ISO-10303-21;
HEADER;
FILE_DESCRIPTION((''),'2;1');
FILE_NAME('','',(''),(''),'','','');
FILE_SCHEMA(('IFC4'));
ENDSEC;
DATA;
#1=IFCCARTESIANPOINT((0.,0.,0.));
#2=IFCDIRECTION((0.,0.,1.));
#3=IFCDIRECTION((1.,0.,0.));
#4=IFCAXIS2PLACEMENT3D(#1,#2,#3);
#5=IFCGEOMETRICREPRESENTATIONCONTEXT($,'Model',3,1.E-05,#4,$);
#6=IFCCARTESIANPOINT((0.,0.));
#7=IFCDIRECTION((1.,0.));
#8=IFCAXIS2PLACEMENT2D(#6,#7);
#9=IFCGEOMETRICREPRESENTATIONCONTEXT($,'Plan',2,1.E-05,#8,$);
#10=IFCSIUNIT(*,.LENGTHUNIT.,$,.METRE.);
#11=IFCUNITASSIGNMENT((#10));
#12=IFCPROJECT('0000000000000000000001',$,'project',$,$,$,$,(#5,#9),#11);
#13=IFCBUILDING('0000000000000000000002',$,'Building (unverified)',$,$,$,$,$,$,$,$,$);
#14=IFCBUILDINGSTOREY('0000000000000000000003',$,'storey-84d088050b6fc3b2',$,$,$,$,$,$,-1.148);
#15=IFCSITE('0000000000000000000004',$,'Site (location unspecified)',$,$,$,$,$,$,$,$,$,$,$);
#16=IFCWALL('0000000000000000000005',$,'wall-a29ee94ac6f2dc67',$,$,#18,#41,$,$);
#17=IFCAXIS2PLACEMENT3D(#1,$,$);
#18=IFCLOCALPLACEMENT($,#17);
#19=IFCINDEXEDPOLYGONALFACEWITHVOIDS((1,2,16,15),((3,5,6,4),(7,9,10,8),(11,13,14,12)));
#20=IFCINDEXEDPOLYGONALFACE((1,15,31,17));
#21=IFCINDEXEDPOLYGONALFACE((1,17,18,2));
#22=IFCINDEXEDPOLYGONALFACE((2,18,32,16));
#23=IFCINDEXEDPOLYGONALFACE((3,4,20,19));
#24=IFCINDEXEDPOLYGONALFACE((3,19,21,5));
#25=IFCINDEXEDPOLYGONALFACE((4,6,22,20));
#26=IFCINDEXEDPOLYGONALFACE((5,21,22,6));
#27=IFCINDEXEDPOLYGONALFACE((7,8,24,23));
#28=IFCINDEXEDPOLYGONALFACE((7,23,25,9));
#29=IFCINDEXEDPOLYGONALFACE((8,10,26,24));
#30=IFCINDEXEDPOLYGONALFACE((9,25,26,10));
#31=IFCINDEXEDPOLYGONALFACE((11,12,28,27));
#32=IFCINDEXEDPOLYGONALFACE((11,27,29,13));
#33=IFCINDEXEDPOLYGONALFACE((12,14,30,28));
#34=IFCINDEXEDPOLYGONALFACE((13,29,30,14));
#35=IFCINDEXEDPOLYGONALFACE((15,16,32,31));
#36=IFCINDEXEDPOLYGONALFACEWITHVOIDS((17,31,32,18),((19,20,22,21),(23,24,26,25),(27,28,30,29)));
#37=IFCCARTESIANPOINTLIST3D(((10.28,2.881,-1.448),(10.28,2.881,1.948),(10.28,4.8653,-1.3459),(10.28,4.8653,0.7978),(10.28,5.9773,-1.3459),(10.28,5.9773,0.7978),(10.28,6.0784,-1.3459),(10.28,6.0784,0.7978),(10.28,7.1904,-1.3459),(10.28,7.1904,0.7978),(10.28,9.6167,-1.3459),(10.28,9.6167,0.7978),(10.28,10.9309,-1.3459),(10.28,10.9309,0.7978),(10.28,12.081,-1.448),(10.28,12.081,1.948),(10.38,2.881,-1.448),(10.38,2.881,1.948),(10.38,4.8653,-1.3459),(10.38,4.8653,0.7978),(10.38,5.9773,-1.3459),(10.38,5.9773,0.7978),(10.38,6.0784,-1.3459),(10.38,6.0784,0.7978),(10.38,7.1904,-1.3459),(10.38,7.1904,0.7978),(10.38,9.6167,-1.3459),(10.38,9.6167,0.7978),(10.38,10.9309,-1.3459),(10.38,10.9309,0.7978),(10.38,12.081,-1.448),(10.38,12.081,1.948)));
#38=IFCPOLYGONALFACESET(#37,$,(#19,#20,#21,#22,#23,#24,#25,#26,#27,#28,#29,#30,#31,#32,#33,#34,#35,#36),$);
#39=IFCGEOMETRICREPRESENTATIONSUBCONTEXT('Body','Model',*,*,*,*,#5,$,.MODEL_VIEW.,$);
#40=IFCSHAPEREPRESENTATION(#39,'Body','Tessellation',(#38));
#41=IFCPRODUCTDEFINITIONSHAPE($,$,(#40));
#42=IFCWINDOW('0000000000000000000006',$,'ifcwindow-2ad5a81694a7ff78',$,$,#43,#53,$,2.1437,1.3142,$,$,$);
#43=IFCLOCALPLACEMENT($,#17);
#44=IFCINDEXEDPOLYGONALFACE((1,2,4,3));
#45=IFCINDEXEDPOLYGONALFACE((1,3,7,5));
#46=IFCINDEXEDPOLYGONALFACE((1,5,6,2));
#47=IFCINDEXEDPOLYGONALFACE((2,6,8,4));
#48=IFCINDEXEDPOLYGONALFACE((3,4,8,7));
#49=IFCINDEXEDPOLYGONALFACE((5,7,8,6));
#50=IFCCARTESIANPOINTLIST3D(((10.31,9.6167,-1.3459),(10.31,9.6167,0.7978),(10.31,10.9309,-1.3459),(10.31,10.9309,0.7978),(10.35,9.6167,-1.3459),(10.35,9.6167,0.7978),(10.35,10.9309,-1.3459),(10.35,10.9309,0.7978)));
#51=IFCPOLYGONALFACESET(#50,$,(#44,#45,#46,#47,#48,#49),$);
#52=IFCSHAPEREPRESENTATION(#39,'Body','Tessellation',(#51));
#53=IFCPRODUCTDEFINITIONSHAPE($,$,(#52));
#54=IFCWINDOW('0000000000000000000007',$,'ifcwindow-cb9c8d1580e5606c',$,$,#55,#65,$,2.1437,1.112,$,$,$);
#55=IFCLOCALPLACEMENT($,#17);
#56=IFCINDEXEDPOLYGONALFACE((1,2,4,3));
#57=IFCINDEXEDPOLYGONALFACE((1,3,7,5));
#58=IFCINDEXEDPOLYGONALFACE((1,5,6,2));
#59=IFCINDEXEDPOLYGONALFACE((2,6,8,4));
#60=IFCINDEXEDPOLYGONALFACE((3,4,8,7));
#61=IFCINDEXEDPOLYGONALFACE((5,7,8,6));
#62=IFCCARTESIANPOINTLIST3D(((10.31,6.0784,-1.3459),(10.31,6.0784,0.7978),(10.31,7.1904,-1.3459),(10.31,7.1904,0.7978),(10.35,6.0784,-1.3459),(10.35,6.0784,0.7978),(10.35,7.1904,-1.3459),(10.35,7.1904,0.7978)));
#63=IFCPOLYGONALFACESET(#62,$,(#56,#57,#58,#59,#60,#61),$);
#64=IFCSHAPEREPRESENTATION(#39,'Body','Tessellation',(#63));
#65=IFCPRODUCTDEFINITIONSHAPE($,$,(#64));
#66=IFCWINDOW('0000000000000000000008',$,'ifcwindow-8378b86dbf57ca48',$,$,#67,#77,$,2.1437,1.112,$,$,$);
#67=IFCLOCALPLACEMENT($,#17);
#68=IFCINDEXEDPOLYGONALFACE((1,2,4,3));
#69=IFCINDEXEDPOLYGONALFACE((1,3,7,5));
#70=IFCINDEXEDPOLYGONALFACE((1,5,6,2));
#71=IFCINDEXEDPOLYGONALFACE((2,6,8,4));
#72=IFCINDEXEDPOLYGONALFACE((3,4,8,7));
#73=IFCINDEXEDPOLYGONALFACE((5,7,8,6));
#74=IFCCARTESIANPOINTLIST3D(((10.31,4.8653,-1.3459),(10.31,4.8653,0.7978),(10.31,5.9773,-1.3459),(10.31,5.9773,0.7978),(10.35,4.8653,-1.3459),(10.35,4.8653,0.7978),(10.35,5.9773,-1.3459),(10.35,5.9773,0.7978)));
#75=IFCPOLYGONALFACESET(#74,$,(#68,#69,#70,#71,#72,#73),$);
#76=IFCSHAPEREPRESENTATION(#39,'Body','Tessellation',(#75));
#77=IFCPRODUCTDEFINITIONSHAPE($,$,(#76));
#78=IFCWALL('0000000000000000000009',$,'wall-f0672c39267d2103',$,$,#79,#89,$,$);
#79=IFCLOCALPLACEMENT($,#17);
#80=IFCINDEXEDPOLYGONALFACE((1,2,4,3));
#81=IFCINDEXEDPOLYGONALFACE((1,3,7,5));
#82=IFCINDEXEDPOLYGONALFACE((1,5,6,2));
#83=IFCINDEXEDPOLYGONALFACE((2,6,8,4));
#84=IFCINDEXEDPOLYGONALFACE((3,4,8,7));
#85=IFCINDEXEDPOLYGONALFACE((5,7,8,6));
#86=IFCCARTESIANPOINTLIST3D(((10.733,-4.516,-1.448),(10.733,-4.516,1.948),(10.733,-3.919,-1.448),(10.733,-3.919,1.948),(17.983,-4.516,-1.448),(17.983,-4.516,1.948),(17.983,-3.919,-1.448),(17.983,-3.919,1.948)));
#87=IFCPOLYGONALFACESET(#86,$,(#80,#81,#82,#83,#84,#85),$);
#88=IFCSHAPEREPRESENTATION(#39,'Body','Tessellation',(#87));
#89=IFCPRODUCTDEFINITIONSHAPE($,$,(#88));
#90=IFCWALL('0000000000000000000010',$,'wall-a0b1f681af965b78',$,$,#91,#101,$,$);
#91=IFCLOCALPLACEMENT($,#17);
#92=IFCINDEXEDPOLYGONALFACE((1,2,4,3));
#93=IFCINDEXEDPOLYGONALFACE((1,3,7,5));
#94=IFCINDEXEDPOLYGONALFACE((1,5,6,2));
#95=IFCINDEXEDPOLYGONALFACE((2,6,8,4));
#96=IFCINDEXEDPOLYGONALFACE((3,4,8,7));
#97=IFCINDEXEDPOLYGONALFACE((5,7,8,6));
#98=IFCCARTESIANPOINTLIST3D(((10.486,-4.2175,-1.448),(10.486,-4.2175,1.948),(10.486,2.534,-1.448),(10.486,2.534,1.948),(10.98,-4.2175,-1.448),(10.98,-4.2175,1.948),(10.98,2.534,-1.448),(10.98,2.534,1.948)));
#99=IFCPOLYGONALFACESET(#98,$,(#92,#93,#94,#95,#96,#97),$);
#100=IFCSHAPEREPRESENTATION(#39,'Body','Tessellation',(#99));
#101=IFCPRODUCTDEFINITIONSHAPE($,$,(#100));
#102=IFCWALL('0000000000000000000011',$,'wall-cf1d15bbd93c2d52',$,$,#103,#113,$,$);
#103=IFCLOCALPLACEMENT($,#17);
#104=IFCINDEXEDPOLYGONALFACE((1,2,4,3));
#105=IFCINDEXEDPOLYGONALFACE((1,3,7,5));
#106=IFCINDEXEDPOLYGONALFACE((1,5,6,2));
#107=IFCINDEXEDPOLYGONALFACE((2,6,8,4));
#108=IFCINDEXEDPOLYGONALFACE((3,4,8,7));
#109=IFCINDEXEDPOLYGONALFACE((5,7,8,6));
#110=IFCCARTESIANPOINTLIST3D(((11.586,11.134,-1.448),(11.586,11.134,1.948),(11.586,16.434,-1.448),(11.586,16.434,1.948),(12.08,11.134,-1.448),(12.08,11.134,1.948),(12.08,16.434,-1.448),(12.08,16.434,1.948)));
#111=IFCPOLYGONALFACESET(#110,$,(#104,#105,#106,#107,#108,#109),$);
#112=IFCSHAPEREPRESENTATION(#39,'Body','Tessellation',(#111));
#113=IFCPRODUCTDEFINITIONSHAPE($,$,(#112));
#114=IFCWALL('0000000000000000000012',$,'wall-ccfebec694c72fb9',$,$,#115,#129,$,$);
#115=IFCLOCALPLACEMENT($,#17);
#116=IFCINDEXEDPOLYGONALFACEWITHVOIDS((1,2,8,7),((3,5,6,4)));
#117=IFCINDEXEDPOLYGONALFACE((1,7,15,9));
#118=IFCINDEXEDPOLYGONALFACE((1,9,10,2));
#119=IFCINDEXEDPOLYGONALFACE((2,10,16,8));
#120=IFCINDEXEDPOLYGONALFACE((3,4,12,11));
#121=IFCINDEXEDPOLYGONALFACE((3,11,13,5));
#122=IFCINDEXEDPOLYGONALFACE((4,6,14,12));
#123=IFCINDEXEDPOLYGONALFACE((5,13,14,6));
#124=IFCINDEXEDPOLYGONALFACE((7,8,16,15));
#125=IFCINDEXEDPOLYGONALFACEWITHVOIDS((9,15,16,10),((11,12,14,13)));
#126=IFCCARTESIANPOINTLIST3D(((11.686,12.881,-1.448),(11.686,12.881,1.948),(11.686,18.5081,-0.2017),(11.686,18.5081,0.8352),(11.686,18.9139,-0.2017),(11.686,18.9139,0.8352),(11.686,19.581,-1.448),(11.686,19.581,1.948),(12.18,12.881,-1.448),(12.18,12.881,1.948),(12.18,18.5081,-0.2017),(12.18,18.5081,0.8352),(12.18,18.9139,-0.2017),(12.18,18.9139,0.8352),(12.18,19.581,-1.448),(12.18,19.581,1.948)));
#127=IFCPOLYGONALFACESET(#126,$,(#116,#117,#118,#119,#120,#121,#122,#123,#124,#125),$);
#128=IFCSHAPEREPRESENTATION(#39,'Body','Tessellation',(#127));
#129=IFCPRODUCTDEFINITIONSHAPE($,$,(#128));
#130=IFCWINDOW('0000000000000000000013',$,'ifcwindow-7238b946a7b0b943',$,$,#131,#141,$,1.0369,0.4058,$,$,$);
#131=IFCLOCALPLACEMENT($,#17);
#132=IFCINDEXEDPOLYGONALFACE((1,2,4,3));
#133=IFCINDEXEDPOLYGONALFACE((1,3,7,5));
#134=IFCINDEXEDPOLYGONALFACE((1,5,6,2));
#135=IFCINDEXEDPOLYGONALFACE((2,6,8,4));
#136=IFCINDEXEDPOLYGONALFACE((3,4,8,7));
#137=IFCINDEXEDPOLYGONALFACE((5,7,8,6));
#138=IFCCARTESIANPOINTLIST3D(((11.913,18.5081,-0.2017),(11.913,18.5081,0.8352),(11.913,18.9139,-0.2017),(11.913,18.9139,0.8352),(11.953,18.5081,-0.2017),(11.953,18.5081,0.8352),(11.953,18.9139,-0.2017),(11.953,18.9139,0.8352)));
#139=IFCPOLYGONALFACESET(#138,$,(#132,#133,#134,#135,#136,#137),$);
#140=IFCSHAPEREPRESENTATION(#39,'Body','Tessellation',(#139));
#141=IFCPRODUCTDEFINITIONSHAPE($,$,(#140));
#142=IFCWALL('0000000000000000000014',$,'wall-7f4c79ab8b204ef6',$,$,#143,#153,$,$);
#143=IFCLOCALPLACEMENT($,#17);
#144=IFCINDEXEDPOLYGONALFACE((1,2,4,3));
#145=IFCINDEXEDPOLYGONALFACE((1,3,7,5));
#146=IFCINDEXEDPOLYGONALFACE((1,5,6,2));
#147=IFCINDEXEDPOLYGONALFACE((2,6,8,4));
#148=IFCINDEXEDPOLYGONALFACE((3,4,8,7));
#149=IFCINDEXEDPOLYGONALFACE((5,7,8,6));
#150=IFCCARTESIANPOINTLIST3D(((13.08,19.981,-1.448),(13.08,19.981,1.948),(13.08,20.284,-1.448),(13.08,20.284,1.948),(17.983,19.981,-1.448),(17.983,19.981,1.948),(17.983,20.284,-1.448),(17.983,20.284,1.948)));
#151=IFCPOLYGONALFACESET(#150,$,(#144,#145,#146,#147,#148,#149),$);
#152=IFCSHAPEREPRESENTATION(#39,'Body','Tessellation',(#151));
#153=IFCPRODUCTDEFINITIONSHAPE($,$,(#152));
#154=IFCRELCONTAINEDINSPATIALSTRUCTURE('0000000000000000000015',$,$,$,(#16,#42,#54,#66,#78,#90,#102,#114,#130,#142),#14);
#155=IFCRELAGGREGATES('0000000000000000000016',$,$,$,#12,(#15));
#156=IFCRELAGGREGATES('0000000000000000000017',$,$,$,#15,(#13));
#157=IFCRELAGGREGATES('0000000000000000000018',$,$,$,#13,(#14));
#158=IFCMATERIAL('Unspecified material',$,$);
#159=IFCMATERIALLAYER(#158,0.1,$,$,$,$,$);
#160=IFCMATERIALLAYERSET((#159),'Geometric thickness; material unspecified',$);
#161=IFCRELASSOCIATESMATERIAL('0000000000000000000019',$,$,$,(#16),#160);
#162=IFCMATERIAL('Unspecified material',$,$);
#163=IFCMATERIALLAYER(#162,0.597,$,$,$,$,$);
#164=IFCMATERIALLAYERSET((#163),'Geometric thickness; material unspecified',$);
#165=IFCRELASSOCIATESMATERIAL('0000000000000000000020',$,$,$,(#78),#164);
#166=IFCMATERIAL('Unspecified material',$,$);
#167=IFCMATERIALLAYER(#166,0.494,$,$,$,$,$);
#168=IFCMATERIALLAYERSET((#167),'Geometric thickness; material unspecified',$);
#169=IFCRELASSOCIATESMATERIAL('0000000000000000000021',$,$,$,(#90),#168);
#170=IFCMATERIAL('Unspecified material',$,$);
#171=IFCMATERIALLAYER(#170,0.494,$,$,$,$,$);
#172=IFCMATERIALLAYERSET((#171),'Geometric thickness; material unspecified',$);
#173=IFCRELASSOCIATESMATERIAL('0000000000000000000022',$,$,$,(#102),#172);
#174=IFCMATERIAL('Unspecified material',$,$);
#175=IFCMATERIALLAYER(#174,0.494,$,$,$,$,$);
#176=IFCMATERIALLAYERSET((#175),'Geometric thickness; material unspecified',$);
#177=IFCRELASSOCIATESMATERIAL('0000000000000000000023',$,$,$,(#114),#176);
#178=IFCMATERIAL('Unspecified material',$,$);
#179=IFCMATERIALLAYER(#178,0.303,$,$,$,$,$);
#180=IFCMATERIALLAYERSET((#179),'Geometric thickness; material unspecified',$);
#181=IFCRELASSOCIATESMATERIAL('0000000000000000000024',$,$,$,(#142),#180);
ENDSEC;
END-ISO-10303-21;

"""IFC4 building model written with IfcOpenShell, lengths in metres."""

from ifc_helpers import new_model, si_unit, frame, origin_with_axes, origin_2d_with_axis, place, context, subcontext, project, spatial, indexed_curve, outline, extrude, material, layer, layer_set, layer_usage, element, fill, save


model = new_model("IFC4")

# Units and contexts
model_context = context("Model", 3, precision=1e-05, world=origin_with_axes())
plan_context = context("Plan", 2, precision=1e-05, world=origin_2d_with_axis())
body_context = subcontext(model_context, "Body", "Model", "MODEL_VIEW")
ifc_project = project(units=[si_unit("LENGTHUNIT", "METRE")], contexts=[model_context, plan_context])

# Site, building, storey
site = spatial("IfcSite", under=ifc_project, Name="Site (location unspecified)")
building = spatial("IfcBuilding", under=site, Name="Building (unverified)")
storey = spatial("IfcBuildingStorey", under=building, Name="storey-84d088050b6fc3b2", Elevation=-1.148)

# Wall, openings, windows
ifc_material_1 = material(Name="Unspecified material")
ifc_layer_1 = layer(ifc_material_1, 0.1)
ifc_layer_set_1 = layer_set([ifc_layer_1], Name="Geometric thickness; material unspecified")
ifc_layer_usage_1 = layer_usage(ifc_layer_set_1, "AXIS2", "POSITIVE", -0.05)
wall_1_placement = place(None, frame((10.33, 12.081, -1.448), z_axis=(0.0, 0.0, 1.0), x_axis=(0.0, -1.0, 0.0)))
wall_1 = element("IfcWall", 1, at=wall_1_placement, inside=storey, material=ifc_layer_usage_1, Name="wall-a29ee94ac6f2dc67", context=body_context, shape_type="SweptSolid", body=[
    extrude(outline(indexed_curve([(0.0, 0.0), (0.0, 0.1), (9.2, 0.1), (9.2, 0.0), (0.0, 0.0)], self_intersect=False)), frame((0.0, -0.05, 0.0), z_axis=(0.0, 0.0, 1.0), x_axis=(1.0, 0.0, 0.0)), (0.0, 0.0, 1.0), 3.396),
])
opening_1_placement = place(wall_1_placement, frame((1.1501, -0.06, 0.1021), z_axis=(0.0, 0.0, 1.0), x_axis=(1.0, 0.0, 0.0)))
opening_1 = element("IfcOpeningElement", 2, at=opening_1_placement, cuts=wall_1, context=body_context, shape_type="SweptSolid", body=[
    extrude(outline(indexed_curve([(0.0, 0.0), (0.0, 0.12), (1.3142, 0.12), (1.3142, 0.0), (0.0, 0.0)], self_intersect=False)), origin_with_axes(), (0.0, 0.0, 1.0), 2.1437),
])
opening_2_placement = place(wall_1_placement, frame((4.8906, -0.06, 0.1021), z_axis=(0.0, 0.0, 1.0), x_axis=(1.0, 0.0, 0.0)))
opening_2 = element("IfcOpeningElement", 3, at=opening_2_placement, cuts=wall_1, context=body_context, shape_type="SweptSolid", body=[
    extrude(outline(indexed_curve([(0.0, 0.0), (0.0, 0.12), (1.112, 0.12), (1.112, 0.0), (0.0, 0.0)], self_intersect=False)), origin_with_axes(), (0.0, 0.0, 1.0), 2.1437),
])
opening_3_placement = place(wall_1_placement, frame((6.1037, -0.06, 0.1021), z_axis=(0.0, 0.0, 1.0), x_axis=(1.0, 0.0, 0.0)))
opening_3 = element("IfcOpeningElement", 4, at=opening_3_placement, cuts=wall_1, context=body_context, shape_type="SweptSolid", body=[
    extrude(outline(indexed_curve([(0.0, 0.0), (0.0, 0.12), (1.112, 0.12), (1.112, 0.0), (0.0, 0.0)], self_intersect=False)), origin_with_axes(), (0.0, 0.0, 1.0), 2.1437),
])
window_1_placement = place(None, frame((10.31, 10.9309, -1.3459), z_axis=(0.0, 0.0, 1.0), x_axis=(0.0, -1.0, 0.0)))
window_1 = element("IfcWindow", 5, at=window_1_placement, inside=storey, Name="ifcwindow-2ad5a81694a7ff78", OverallHeight=2.1437, OverallWidth=1.3142, context=body_context, shape_type="SweptSolid", body=[
    extrude(outline(indexed_curve([(0.0, 0.0), (0.0, 0.04), (1.3142, 0.04), (1.3142, 0.0), (0.0, 0.0)], self_intersect=False)), origin_with_axes(), (0.0, 0.0, 1.0), 2.1437),
])
fill(opening_1, window_1)
window_2_placement = place(None, frame((10.31, 7.1904, -1.3459), z_axis=(0.0, 0.0, 1.0), x_axis=(0.0, -1.0, 0.0)))
window_2 = element("IfcWindow", 6, at=window_2_placement, inside=storey, Name="ifcwindow-cb9c8d1580e5606c", OverallHeight=2.1437, OverallWidth=1.112, context=body_context, shape_type="SweptSolid", body=[
    extrude(outline(indexed_curve([(0.0, 0.0), (0.0, 0.04), (1.112, 0.04), (1.112, 0.0), (0.0, 0.0)], self_intersect=False)), origin_with_axes(), (0.0, 0.0, 1.0), 2.1437),
])
fill(opening_2, window_2)
window_3_placement = place(None, frame((10.31, 5.9773, -1.3459), z_axis=(0.0, 0.0, 1.0), x_axis=(0.0, -1.0, 0.0)))
window_3 = element("IfcWindow", 7, at=window_3_placement, inside=storey, Name="ifcwindow-8378b86dbf57ca48", OverallHeight=2.1437, OverallWidth=1.112, context=body_context, shape_type="SweptSolid", body=[
    extrude(outline(indexed_curve([(0.0, 0.0), (0.0, 0.04), (1.112, 0.04), (1.112, 0.0), (0.0, 0.0)], self_intersect=False)), origin_with_axes(), (0.0, 0.0, 1.0), 2.1437),
])
fill(opening_3, window_3)

# Walls
ifc_material_2 = material(Name="Unspecified material")
ifc_layer_2 = layer(ifc_material_2, 0.597)
ifc_layer_set_2 = layer_set([ifc_layer_2], Name="Geometric thickness; material unspecified")
ifc_layer_usage_2 = layer_usage(ifc_layer_set_2, "AXIS2", "POSITIVE", -0.2985)
wall_2_placement = place(None, frame((17.983, -4.2175, -1.448), z_axis=(0.0, 0.0, 1.0), x_axis=(-1.0, 0.0, 0.0)))
element("IfcWall", 8, at=wall_2_placement, inside=storey, material=ifc_layer_usage_2, Name="wall-f0672c39267d2103", context=body_context, shape_type="SweptSolid", body=[
    extrude(outline(indexed_curve([(0.0, 0.0), (0.0, 0.597), (7.25, 0.597), (7.25, 0.0), (0.0, 0.0)], self_intersect=False)), frame((0.0, -0.2985, 0.0), z_axis=(0.0, 0.0, 1.0), x_axis=(1.0, 0.0, 0.0)), (0.0, 0.0, 1.0), 3.396),
])
ifc_material_3 = material(Name="Unspecified material")
ifc_layer_3 = layer(ifc_material_3, 0.494)
ifc_layer_set_3 = layer_set([ifc_layer_3], Name="Geometric thickness; material unspecified")
ifc_layer_usage_3 = layer_usage(ifc_layer_set_3, "AXIS2", "POSITIVE", -0.247)
wall_3_placement = place(None, frame((10.733, -4.2175, -1.448), z_axis=(0.0, 0.0, 1.0), x_axis=(0.0, 1.0, 0.0)))
element("IfcWall", 9, at=wall_3_placement, inside=storey, material=ifc_layer_usage_3, Name="wall-a0b1f681af965b78", context=body_context, shape_type="SweptSolid", body=[
    extrude(outline(indexed_curve([(0.0, 0.0), (0.0, 0.494), (6.7515, 0.494), (6.7515, 0.0), (0.0, 0.0)], self_intersect=False)), frame((0.0, -0.247, 0.0), z_axis=(0.0, 0.0, 1.0), x_axis=(1.0, 0.0, 0.0)), (0.0, 0.0, 1.0), 3.396),
])
ifc_material_4 = material(Name="Unspecified material")
ifc_layer_4 = layer(ifc_material_4, 0.494)
ifc_layer_set_4 = layer_set([ifc_layer_4], Name="Geometric thickness; material unspecified")
ifc_layer_usage_4 = layer_usage(ifc_layer_set_4, "AXIS2", "POSITIVE", -0.247)
wall_4_placement = place(None, frame((11.833, 11.134, -1.448), z_axis=(0.0, 0.0, 1.0), x_axis=(0.0, 1.0, 0.0)))
element("IfcWall", 10, at=wall_4_placement, inside=storey, material=ifc_layer_usage_4, Name="wall-cf1d15bbd93c2d52", context=body_context, shape_type="SweptSolid", body=[
    extrude(outline(indexed_curve([(0.0, 0.0), (0.0, 0.494), (5.3, 0.494), (5.3, 0.0), (0.0, 0.0)], self_intersect=False)), frame((0.0, -0.247, 0.0), z_axis=(0.0, 0.0, 1.0), x_axis=(1.0, 0.0, 0.0)), (0.0, 0.0, 1.0), 3.396),
])

# Wall, opening, window
ifc_material_5 = material(Name="Unspecified material")
ifc_layer_5 = layer(ifc_material_5, 0.494)
ifc_layer_set_5 = layer_set([ifc_layer_5], Name="Geometric thickness; material unspecified")
ifc_layer_usage_5 = layer_usage(ifc_layer_set_5, "AXIS2", "POSITIVE", -0.247)
wall_5_placement = place(None, frame((11.933, 12.881, -1.448), z_axis=(0.0, 0.0, 1.0), x_axis=(0.0, 1.0, 0.0)))
wall_5 = element("IfcWall", 11, at=wall_5_placement, inside=storey, material=ifc_layer_usage_5, Name="wall-ccfebec694c72fb9", context=body_context, shape_type="SweptSolid", body=[
    extrude(outline(indexed_curve([(0.0, 0.0), (0.0, 0.494), (6.7, 0.494), (6.7, 0.0), (0.0, 0.0)], self_intersect=False)), frame((0.0, -0.247, 0.0), z_axis=(0.0, 0.0, 1.0), x_axis=(1.0, 0.0, 0.0)), (0.0, 0.0, 1.0), 3.396),
])
opening_4_placement = place(wall_5_placement, frame((5.6271, -0.257, 1.2463), z_axis=(0.0, 0.0, 1.0), x_axis=(1.0, 0.0, 0.0)))
opening_4 = element("IfcOpeningElement", 12, at=opening_4_placement, cuts=wall_5, context=body_context, shape_type="SweptSolid", body=[
    extrude(outline(indexed_curve([(0.0, 0.0), (0.0, 0.514), (0.4058, 0.514), (0.4058, 0.0), (0.0, 0.0)], self_intersect=False)), origin_with_axes(), (0.0, 0.0, 1.0), 1.0369),
])
window_4_placement = place(None, frame((11.953, 18.5081, -0.2017), z_axis=(0.0, 0.0, 1.0), x_axis=(0.0, 1.0, 0.0)))
window_4 = element("IfcWindow", 13, at=window_4_placement, inside=storey, Name="ifcwindow-7238b946a7b0b943", OverallHeight=1.0369, OverallWidth=0.4058, context=body_context, shape_type="SweptSolid", body=[
    extrude(outline(indexed_curve([(0.0, 0.0), (0.0, 0.04), (0.4058, 0.04), (0.4058, 0.0), (0.0, 0.0)], self_intersect=False)), origin_with_axes(), (0.0, 0.0, 1.0), 1.0369),
])
fill(opening_4, window_4)

# Wall
ifc_material_6 = material(Name="Unspecified material")
ifc_layer_6 = layer(ifc_material_6, 0.303)
ifc_layer_set_6 = layer_set([ifc_layer_6], Name="Geometric thickness; material unspecified")
ifc_layer_usage_6 = layer_usage(ifc_layer_set_6, "AXIS2", "POSITIVE", -0.1515)
wall_6_placement = place(None, frame((13.08, 20.1325, -1.448), z_axis=(0.0, 0.0, 1.0), x_axis=(1.0, 0.0, 0.0)))
element("IfcWall", 14, at=wall_6_placement, inside=storey, material=ifc_layer_usage_6, Name="wall-7f4c79ab8b204ef6", context=body_context, shape_type="SweptSolid", body=[
    extrude(outline(indexed_curve([(0.0, 0.0), (0.0, 0.303), (4.903, 0.303), (4.903, 0.0), (0.0, 0.0)], self_intersect=False)), frame((0.0, -0.1515, 0.0), z_axis=(0.0, 0.0, 1.0), x_axis=(1.0, 0.0, 0.0)), (0.0, 0.0, 1.0), 3.396),
])

save(model, "model.ifc")
